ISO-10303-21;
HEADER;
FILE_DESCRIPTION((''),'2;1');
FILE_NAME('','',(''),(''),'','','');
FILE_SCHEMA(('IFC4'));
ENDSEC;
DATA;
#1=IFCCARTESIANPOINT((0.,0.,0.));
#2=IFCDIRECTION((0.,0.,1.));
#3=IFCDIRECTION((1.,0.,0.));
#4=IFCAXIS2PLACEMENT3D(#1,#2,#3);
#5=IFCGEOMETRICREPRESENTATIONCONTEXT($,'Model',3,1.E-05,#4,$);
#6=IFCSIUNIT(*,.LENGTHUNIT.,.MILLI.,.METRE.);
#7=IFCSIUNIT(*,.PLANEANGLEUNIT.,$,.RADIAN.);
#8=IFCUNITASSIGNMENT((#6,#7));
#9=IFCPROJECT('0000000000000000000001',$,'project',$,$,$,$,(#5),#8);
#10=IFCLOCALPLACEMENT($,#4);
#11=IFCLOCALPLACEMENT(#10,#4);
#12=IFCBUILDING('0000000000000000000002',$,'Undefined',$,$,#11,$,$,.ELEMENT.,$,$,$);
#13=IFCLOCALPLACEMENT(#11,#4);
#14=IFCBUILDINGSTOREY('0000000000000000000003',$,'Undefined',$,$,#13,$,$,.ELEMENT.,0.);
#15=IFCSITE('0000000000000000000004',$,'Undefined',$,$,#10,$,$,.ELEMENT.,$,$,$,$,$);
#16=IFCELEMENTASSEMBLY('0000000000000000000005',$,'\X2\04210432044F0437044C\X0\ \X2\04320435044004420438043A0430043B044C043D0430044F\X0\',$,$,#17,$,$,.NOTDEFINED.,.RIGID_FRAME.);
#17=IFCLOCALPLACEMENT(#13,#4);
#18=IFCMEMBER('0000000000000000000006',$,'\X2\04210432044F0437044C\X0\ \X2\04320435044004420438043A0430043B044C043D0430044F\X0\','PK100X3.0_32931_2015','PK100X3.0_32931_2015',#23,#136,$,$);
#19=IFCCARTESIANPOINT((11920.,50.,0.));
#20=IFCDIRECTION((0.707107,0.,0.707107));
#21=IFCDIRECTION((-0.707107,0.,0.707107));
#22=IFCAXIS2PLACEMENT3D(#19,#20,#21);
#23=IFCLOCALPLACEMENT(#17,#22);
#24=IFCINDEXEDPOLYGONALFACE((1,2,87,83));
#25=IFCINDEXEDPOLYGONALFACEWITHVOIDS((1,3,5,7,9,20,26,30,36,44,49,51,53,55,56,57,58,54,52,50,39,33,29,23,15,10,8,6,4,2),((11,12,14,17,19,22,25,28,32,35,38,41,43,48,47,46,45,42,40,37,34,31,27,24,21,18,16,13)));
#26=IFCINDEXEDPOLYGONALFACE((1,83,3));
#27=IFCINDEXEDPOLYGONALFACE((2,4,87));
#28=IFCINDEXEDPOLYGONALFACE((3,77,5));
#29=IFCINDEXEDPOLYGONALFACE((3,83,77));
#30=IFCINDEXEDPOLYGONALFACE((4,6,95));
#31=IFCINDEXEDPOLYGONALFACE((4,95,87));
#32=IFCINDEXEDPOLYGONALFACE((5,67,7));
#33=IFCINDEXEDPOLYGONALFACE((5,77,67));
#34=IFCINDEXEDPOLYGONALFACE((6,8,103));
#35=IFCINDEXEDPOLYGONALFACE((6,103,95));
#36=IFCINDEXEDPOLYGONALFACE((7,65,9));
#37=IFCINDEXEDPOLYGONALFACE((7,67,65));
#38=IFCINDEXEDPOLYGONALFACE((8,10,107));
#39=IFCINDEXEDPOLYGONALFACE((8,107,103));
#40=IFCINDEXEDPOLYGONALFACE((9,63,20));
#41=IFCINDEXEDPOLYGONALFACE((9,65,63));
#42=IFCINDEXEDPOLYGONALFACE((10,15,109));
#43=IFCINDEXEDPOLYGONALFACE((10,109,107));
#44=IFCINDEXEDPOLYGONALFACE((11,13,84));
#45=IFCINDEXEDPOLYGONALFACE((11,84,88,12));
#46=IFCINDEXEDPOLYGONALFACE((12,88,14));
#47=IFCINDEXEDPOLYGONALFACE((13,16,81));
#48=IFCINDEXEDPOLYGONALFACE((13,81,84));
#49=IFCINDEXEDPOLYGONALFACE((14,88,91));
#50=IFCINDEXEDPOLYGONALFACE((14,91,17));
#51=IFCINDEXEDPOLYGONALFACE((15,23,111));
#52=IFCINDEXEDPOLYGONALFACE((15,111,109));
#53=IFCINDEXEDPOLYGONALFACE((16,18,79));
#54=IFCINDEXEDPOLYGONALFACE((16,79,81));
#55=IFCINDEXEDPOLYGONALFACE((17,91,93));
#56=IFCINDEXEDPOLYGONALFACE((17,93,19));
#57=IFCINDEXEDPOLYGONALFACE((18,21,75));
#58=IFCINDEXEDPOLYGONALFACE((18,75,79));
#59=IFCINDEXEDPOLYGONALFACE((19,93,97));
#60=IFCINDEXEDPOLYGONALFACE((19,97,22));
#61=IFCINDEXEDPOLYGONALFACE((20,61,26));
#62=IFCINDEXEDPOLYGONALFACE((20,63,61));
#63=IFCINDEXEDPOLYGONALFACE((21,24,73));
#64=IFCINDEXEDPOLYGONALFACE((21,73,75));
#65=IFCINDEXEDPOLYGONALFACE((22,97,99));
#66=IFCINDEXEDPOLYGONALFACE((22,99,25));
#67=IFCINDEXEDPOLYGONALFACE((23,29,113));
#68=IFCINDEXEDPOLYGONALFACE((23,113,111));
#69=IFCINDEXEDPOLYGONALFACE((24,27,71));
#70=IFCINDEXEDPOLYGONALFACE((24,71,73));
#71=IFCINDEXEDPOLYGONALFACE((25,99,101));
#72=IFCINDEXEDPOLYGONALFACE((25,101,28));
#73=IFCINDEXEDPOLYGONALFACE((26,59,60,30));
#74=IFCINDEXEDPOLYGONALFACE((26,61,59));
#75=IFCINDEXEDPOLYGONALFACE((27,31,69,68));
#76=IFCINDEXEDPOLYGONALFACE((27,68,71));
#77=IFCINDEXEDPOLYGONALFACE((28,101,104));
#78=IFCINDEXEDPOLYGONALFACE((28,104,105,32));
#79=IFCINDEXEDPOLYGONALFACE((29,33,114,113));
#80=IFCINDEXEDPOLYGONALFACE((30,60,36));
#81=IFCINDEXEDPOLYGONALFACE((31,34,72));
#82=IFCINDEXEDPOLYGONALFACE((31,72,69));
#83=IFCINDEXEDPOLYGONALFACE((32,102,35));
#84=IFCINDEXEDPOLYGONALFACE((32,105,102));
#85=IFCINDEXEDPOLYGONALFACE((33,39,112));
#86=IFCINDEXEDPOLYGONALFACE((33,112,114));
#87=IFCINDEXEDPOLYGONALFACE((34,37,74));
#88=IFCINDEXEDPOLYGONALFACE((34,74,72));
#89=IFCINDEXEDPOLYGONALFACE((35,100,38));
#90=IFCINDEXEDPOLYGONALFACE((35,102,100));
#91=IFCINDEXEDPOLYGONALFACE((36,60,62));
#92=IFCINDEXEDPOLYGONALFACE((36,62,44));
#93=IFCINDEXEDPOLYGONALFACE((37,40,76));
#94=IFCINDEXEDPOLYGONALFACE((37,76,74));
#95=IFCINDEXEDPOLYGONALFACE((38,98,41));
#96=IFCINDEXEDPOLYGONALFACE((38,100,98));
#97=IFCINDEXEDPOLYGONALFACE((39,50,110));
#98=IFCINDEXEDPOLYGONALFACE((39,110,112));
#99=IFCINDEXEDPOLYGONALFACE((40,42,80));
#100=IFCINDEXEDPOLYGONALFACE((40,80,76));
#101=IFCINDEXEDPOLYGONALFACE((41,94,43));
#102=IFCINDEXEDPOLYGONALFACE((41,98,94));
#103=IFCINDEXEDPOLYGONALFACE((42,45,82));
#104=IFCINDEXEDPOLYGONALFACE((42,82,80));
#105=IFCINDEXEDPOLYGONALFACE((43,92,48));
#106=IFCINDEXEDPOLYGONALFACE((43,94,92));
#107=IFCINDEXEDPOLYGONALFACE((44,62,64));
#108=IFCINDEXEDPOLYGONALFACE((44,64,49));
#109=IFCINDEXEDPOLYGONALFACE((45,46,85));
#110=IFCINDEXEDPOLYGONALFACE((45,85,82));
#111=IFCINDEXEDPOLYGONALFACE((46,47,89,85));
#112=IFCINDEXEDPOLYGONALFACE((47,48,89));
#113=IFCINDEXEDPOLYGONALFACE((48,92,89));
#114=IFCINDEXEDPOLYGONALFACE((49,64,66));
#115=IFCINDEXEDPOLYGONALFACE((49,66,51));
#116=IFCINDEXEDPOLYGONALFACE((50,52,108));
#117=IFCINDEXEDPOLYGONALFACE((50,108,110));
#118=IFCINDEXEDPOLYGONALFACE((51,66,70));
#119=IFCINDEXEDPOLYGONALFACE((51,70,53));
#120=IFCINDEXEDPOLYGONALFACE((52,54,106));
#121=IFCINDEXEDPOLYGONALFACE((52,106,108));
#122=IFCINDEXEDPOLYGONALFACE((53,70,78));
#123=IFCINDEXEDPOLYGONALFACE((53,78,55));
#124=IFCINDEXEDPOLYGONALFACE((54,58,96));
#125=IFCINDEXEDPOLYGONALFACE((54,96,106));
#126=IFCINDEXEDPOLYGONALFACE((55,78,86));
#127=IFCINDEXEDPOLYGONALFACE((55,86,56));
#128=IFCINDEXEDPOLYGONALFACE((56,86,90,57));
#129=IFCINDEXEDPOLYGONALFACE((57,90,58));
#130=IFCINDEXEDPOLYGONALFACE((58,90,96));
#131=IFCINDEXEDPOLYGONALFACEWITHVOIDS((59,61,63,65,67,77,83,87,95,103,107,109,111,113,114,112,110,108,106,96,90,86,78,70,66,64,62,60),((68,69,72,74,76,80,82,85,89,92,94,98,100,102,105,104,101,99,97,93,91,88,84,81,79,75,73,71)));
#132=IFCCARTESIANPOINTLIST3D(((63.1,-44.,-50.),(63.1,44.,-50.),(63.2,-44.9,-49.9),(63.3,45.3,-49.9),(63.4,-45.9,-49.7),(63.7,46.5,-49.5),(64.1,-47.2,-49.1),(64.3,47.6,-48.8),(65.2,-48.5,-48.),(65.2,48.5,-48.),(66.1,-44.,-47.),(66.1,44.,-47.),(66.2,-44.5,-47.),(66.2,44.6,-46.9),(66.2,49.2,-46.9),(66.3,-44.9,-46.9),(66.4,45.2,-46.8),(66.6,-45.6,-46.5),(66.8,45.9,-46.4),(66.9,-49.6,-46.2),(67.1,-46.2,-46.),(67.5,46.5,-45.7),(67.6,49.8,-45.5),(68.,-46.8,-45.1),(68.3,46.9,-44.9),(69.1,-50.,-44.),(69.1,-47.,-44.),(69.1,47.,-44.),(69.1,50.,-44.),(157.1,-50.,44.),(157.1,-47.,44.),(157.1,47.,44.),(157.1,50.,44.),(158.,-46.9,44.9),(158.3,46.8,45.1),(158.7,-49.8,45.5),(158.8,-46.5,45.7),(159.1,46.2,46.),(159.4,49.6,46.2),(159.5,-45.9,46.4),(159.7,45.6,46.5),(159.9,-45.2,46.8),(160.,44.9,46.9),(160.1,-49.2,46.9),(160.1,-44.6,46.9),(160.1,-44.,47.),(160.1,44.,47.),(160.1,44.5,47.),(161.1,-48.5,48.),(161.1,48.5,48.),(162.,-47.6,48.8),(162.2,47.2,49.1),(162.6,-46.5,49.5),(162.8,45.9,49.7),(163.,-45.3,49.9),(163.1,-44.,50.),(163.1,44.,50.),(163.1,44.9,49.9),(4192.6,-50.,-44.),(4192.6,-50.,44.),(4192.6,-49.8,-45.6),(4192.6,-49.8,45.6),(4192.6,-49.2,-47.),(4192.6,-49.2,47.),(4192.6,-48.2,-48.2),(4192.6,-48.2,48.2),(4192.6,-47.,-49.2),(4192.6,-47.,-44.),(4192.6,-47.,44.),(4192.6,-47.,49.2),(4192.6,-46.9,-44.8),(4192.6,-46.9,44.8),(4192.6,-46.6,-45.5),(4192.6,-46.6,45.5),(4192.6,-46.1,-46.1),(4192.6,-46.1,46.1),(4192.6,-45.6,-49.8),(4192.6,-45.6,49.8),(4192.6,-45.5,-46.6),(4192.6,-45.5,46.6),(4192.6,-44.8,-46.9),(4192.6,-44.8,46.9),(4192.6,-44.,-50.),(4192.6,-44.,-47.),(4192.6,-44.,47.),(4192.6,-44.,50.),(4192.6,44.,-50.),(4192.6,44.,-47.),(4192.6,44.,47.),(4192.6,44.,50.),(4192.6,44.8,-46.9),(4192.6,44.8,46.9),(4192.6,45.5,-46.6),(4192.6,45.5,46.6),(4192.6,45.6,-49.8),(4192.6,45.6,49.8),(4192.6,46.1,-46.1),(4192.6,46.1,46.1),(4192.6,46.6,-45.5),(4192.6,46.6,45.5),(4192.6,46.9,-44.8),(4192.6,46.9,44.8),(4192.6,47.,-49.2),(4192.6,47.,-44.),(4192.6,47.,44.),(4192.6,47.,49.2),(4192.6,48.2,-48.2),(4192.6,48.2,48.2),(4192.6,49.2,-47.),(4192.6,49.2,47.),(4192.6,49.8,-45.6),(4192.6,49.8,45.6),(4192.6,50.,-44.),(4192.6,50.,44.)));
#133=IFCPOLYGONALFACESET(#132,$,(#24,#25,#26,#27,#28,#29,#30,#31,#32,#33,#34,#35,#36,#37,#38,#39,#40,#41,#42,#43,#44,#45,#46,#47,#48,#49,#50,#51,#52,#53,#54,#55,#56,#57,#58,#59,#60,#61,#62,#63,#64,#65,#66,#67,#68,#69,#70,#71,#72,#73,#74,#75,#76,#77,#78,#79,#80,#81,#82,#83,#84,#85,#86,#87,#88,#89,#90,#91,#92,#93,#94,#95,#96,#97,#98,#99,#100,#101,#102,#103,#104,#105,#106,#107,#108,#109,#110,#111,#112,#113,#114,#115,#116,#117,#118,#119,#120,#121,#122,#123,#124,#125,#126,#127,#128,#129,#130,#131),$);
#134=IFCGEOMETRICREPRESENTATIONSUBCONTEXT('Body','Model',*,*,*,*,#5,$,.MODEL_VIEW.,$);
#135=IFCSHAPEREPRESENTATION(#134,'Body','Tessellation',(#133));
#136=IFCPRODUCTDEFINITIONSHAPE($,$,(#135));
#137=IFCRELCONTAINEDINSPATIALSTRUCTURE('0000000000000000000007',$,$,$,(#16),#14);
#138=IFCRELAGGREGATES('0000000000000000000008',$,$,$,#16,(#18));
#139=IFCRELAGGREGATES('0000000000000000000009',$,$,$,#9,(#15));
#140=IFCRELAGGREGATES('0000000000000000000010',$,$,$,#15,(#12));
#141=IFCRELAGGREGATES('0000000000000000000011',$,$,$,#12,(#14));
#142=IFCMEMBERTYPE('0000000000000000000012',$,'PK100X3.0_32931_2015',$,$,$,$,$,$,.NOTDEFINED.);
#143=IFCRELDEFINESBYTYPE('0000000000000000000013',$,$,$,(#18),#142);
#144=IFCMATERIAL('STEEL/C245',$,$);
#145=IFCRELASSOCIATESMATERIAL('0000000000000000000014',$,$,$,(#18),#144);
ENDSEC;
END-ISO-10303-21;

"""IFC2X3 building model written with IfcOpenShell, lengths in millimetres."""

from ifc_helpers import new_model, si_unit, frame, origin_with_axes, origin_2d_with_axis, place, context, subcontext, project, spatial, hollow_rectangle, extrude, clip, halfspace, material, type_object, element, aggregate, save


model = new_model("IFC2X3")

# Units and contexts
model_context = context("Model", 3, precision=1e-05, world=origin_with_axes())
body_context = subcontext(model_context, "Body", "Model", "MODEL_VIEW")
ifc_project = project(units=[si_unit("LENGTHUNIT", "METRE", prefix="MILLI"), si_unit("PLANEANGLEUNIT", "RADIAN")], contexts=[model_context])

# Site, building, storey
site_placement = place(None, origin_with_axes())
site = spatial("IfcSite", under=ifc_project, at=site_placement, Name="Undefined", CompositionType="ELEMENT")
building_placement = place(site_placement, origin_with_axes())
building = spatial("IfcBuilding", under=site, at=building_placement, Name="Undefined", CompositionType="ELEMENT")
storey_placement = place(building_placement, origin_with_axes())
storey = spatial("IfcBuildingStorey", under=building, at=storey_placement, Name="Undefined", CompositionType="ELEMENT", Elevation=0.0)

# Shared definitions
ifc_material = material(Name="STEEL/C245")

# Element assembly, member
member_type_1 = type_object("IfcMemberType", Name="PK100X3.0_32931_2015", PredefinedType="NOTDEFINED")
assembly_1_placement = place(storey_placement, origin_with_axes())
assembly_1 = element("IfcElementAssembly", 1, at=assembly_1_placement, inside=storey, Name="Связь вертикальная", AssemblyPlace="NOTDEFINED", PredefinedType="RIGID_FRAME")
member_1_placement = place(assembly_1_placement, frame((11920.0, 50.0, 0.0), z_axis=(0.707107, 0.0, 0.707107), x_axis=(-0.707107, 0.0, 0.707107)))
member_1 = element("IfcMember", 2, at=member_1_placement, type_object=member_type_1, material=ifc_material, Name="Связь вертикальная", Description="PK100X3.0_32931_2015", ObjectType="PK100X3.0_32931_2015", context=body_context, shape_type="Clipping", body=[
    clip(clip(extrude(hollow_rectangle(XDim=100.0, YDim=100.0, WallThickness=3.0, InnerFilletRadius=3.0, OuterFilletRadius=6.0, at=origin_2d_with_axis()), frame((4293.6, 0.0, 0.0), z_axis=(-1.0, 0.0, 0.0), x_axis=(0.0, -1.0, 0.0)), (0.0, 0.0, 1.0), 4281.5), halfspace(frame((4192.6, 50.0, -95.9), z_axis=(-1.0, 0.0, 0.0), x_axis=(0.0, 1.0, 0.0)), True)), halfspace(frame((281.0, 50.0, 167.8), z_axis=(0.707107, 0.0, -0.707107), x_axis=(0.707107, 0.0, 0.707107)), True)),
])
aggregate(assembly_1, [member_1])

save(model, "model.ifc")
